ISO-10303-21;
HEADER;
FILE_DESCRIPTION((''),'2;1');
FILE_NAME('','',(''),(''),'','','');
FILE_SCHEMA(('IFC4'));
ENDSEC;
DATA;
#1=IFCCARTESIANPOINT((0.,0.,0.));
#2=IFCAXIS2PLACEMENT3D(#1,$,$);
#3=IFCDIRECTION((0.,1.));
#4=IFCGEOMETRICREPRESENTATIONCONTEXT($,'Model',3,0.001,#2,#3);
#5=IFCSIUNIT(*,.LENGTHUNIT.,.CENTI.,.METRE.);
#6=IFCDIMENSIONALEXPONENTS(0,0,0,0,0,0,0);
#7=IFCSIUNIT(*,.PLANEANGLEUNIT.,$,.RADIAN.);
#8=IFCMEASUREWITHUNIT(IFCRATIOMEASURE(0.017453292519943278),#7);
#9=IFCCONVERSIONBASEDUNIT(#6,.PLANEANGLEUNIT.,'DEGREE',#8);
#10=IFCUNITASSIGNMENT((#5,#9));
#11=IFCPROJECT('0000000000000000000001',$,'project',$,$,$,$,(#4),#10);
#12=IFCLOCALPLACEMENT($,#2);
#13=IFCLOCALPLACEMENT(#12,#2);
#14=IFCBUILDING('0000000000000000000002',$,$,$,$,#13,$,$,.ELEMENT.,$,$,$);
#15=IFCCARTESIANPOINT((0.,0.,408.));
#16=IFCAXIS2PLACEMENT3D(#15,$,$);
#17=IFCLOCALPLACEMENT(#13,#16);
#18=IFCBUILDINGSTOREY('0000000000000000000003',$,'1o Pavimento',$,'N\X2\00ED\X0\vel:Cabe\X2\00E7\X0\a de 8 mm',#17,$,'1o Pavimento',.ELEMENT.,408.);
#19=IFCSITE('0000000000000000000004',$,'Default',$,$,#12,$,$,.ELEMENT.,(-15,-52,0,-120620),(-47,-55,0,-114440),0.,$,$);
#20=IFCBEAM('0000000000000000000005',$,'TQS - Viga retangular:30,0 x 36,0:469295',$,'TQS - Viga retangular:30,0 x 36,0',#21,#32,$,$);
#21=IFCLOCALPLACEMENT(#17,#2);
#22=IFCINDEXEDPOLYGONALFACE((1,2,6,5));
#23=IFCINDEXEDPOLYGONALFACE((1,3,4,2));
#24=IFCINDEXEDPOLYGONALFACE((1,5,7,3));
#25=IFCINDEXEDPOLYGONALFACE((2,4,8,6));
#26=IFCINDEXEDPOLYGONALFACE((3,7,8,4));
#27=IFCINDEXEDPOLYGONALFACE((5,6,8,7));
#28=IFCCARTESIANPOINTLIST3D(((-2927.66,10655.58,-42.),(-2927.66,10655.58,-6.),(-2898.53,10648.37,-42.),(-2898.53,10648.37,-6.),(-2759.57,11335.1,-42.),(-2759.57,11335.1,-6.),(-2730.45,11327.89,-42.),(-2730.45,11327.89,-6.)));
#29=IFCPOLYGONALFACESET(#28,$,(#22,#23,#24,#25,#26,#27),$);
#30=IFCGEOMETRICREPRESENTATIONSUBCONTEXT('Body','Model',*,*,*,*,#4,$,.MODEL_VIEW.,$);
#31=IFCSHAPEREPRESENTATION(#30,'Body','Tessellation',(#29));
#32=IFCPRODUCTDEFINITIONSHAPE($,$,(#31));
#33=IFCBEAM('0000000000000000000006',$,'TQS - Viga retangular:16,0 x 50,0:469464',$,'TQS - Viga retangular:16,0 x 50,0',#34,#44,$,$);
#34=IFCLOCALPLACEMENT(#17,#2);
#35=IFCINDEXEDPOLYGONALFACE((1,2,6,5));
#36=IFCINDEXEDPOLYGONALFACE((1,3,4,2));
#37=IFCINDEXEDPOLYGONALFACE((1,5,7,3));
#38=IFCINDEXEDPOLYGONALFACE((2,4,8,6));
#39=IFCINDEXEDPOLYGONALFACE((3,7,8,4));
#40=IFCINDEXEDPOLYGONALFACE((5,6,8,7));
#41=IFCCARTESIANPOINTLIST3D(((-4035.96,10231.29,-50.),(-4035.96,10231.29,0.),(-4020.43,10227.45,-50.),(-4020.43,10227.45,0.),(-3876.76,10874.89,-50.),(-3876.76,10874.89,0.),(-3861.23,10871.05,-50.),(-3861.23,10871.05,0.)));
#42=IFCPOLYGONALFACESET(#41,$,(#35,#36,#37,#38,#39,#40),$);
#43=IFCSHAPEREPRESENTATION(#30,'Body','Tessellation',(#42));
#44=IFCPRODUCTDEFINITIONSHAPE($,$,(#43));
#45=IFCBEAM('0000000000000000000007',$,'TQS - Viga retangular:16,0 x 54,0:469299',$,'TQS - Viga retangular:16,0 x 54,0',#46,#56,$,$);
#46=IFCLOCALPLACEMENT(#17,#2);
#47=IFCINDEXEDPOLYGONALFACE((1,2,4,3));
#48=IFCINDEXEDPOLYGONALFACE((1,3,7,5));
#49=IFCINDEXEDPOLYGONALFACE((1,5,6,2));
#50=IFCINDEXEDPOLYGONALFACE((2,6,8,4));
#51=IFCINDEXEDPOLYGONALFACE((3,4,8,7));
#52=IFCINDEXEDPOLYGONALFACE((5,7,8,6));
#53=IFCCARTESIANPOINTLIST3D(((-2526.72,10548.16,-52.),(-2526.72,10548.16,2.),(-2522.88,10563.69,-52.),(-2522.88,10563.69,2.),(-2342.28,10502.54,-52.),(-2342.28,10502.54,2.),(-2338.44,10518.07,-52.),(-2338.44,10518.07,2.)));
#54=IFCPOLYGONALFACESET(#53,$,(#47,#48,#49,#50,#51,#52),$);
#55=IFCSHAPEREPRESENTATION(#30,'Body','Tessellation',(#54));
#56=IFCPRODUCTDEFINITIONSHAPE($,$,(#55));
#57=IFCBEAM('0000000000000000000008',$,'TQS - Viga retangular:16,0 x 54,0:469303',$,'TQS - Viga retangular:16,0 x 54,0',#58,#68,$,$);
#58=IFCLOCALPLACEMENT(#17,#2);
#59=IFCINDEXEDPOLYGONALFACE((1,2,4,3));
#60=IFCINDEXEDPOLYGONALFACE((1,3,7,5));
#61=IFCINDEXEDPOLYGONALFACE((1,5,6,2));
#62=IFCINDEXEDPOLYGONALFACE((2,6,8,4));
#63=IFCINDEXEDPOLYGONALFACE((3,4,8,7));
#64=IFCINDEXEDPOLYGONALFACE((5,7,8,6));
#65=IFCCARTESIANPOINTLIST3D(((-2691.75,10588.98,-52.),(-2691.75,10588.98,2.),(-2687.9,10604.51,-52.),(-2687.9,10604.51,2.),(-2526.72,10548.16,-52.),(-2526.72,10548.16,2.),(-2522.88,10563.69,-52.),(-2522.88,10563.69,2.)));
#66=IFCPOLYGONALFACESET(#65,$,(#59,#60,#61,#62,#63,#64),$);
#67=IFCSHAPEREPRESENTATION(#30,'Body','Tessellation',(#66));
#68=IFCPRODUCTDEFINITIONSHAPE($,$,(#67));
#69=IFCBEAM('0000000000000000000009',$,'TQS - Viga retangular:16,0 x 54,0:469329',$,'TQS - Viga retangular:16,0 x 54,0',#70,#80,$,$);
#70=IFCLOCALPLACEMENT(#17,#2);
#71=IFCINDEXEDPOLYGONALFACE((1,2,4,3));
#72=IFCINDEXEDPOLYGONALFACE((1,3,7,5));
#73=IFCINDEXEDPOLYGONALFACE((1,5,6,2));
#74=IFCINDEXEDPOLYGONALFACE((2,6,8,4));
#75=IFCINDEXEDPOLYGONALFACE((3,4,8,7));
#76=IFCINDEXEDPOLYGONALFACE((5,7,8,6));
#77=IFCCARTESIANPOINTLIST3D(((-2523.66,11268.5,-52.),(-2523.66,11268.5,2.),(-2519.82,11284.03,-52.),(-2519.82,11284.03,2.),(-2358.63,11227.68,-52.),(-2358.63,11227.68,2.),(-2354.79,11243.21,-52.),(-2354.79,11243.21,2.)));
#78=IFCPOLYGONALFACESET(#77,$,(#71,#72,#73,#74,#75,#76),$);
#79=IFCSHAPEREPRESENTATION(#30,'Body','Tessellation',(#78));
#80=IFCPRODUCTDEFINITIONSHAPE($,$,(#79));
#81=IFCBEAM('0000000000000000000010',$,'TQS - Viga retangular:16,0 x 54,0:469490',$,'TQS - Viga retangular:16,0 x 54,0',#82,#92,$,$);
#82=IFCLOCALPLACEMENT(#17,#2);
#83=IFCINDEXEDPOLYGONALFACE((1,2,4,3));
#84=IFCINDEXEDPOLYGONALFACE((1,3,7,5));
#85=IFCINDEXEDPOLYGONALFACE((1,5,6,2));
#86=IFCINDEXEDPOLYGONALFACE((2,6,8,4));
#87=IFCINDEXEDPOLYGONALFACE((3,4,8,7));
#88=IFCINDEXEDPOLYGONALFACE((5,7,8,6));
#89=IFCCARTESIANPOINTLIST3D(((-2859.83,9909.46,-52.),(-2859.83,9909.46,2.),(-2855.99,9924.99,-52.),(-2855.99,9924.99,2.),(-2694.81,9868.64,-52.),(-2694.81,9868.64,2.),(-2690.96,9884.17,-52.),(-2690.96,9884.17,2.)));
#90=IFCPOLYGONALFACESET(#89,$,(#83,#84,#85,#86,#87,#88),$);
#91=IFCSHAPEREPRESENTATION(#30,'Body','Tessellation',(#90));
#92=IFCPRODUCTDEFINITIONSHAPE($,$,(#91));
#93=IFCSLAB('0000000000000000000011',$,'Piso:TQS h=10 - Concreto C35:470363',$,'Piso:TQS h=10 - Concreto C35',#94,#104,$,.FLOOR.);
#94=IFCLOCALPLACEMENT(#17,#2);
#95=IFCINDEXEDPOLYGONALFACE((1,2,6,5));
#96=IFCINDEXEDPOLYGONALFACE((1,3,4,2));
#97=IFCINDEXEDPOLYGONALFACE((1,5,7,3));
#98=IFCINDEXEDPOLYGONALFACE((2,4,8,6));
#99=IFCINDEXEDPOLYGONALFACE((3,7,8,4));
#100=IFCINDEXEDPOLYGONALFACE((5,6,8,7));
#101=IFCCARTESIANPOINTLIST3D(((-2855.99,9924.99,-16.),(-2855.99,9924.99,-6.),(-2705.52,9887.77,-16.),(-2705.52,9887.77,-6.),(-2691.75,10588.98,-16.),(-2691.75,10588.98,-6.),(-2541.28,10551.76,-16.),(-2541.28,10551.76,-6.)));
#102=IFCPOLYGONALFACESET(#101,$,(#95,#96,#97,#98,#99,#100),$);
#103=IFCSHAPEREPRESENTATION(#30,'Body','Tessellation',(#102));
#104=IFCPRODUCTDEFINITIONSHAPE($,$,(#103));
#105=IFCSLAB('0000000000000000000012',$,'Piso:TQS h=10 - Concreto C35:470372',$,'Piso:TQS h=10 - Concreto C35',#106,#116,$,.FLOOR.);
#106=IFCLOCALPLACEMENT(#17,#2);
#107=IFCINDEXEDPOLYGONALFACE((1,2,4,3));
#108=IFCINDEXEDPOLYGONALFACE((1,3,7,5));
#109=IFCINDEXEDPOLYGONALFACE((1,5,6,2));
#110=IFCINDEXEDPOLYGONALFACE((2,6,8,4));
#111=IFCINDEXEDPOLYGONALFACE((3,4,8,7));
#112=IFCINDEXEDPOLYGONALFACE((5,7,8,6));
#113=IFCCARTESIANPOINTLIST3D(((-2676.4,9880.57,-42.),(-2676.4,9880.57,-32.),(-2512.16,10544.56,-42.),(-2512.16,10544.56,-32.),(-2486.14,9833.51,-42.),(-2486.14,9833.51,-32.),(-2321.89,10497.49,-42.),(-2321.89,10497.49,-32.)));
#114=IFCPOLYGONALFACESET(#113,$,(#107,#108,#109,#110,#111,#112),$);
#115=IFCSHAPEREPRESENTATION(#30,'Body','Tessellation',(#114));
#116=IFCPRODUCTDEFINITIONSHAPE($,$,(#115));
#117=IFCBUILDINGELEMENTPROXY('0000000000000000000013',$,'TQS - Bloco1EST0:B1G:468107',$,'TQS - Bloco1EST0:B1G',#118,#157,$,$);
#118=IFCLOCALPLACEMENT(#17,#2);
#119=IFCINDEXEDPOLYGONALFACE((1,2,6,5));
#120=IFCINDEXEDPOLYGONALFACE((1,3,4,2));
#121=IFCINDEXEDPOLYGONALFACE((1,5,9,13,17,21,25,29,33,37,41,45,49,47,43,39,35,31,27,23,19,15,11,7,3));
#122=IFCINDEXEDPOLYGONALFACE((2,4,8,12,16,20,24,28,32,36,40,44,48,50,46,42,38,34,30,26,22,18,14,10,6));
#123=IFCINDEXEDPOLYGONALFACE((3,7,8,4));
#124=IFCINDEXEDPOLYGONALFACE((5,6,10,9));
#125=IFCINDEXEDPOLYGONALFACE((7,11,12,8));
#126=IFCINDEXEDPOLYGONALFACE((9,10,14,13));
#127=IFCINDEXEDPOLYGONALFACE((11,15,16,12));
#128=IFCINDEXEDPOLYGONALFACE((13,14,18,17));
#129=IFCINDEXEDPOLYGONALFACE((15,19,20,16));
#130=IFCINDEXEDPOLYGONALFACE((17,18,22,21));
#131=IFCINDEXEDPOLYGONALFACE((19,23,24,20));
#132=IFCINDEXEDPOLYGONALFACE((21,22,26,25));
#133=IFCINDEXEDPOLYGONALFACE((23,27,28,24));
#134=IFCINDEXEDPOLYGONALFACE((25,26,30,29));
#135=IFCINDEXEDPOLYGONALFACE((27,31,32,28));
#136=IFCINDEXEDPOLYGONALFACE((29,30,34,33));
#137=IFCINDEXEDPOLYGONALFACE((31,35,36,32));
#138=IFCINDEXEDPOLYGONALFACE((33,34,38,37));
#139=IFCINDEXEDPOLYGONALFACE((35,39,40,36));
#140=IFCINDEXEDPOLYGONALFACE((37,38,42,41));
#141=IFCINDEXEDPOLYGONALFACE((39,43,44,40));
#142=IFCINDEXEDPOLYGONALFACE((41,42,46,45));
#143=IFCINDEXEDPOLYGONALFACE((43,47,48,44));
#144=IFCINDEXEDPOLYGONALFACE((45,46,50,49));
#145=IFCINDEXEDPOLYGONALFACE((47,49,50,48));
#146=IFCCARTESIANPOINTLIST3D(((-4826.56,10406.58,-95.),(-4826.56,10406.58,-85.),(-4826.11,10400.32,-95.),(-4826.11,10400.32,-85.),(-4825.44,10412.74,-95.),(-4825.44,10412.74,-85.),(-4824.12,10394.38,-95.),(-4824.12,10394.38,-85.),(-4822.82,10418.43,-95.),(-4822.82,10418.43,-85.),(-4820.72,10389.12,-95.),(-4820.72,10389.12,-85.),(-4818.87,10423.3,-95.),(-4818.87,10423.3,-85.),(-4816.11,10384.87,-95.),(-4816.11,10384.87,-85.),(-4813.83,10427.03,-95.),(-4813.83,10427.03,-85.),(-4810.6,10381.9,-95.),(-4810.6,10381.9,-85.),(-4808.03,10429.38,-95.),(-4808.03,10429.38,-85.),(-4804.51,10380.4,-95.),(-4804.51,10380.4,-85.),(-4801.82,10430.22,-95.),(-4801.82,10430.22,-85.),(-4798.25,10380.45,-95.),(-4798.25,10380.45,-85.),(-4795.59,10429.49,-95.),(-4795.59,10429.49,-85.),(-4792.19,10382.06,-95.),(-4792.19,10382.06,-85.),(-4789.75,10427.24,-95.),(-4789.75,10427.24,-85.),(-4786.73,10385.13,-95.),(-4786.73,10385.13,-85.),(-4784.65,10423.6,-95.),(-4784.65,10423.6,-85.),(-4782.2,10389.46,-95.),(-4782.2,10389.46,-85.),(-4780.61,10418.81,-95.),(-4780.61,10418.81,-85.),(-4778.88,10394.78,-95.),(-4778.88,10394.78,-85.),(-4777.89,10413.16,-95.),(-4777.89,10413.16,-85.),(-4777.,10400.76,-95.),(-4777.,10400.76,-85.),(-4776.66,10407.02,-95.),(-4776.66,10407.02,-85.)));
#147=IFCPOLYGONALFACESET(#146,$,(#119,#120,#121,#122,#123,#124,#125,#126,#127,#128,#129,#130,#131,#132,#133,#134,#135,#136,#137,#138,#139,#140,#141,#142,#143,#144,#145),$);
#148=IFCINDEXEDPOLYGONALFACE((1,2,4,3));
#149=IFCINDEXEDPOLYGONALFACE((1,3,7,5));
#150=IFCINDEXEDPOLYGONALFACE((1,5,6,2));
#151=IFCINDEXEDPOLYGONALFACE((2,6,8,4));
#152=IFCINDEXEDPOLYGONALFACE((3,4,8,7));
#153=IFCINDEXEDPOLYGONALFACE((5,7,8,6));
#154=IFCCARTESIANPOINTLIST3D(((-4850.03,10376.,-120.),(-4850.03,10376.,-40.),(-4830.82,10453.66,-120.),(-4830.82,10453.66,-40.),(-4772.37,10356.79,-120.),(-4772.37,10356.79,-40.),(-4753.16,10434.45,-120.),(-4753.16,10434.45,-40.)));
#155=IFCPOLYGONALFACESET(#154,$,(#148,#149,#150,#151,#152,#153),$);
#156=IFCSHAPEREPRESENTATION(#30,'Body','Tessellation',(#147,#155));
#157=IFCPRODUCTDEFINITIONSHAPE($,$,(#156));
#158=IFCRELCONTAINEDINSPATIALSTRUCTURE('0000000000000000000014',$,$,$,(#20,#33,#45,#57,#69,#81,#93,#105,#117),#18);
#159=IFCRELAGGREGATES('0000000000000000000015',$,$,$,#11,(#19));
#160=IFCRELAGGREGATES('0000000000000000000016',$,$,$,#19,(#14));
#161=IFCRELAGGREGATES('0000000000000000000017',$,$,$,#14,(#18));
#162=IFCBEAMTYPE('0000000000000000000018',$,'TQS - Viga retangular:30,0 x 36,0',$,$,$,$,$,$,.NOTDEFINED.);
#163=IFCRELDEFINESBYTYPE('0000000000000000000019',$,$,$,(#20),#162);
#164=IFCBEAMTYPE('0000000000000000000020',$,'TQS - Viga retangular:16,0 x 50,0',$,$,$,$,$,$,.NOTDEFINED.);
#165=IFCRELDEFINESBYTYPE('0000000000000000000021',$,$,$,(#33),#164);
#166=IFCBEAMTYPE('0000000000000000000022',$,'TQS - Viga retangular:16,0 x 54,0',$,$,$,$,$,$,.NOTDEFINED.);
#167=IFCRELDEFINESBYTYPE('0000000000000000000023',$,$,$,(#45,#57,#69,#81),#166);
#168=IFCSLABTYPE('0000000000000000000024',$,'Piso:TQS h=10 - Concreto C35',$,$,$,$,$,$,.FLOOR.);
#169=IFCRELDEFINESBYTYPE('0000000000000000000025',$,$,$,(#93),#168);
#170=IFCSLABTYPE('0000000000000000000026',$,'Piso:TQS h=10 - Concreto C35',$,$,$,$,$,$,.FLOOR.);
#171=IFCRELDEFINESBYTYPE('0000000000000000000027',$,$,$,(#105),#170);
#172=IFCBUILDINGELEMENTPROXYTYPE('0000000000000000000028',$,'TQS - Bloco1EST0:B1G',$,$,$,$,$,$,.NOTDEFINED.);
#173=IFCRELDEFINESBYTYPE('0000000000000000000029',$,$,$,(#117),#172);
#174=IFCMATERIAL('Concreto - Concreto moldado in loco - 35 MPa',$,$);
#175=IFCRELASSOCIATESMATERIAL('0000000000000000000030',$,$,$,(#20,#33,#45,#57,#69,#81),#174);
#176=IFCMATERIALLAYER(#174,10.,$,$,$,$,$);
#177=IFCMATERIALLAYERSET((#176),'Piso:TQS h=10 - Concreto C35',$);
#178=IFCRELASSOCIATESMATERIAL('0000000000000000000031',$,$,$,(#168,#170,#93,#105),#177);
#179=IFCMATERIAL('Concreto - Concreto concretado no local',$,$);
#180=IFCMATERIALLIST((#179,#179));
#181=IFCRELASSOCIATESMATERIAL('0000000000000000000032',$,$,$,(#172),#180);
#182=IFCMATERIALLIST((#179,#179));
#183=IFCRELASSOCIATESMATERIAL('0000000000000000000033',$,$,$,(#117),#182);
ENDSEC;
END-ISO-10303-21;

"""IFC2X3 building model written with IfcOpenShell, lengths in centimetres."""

from ifc_helpers import new_model, entity, si_unit, converted_unit, direction, frame, frame_2d, origin, origin_2d_with_axis, place, context, subcontext, project, spatial, rectangle, circle, extrude, source, transform, mapped, material, material_list, layer, layer_set, layer_usage, type_object, type_shapes, element, save


model = new_model("IFC2X3")

# Units and contexts
model_context = context("Model", 3, precision=0.001, world=origin(), true_north=direction((0.0, 1.0)))
body_context = subcontext(model_context, "Body", "Model", "MODEL_VIEW")
ifc_project = project(units=[si_unit("LENGTHUNIT", "METRE", prefix="CENTI"), converted_unit("PLANEANGLEUNIT", "DEGREE", entity("IfcRatioMeasure", 0.017453292519943278), si_unit("PLANEANGLEUNIT", "RADIAN"), dimensions=[0, 0, 0, 0, 0, 0, 0])], contexts=[model_context])

# Site, building, storey
site_placement = place(None, origin())
site = spatial("IfcSite", under=ifc_project, at=site_placement, Name="Default", CompositionType="ELEMENT", RefLatitude=(-15, -52, 0, -120620), RefLongitude=(-47, -55, 0, -114440), RefElevation=0.0)
building_placement = place(site_placement, origin())
building = spatial("IfcBuilding", under=site, at=building_placement, CompositionType="ELEMENT")
storey_placement = place(building_placement, frame((0.0, 0.0, 408.0)))
storey = spatial("IfcBuildingStorey", under=building, at=storey_placement, Name="1o Pavimento", ObjectType="Nível:Cabeça de 8 mm", LongName="1o Pavimento", CompositionType="ELEMENT", Elevation=408.0)

# Beams
ifc_material_1 = material(Name="Concreto - Concreto moldado in loco - 35 MPa")
beam_type_1 = type_object("IfcBeamType", Name="TQS - Viga retangular:30,0 x 36,0", PredefinedType="NOTDEFINED")
beam_1_placement = place(storey_placement, frame((-2913.1, 10651.97, -6.0), z_axis=(0.0, 0.0, 1.0), x_axis=(0.240122, 0.970743, 0.0)))
element("IfcBeam", 1, at=beam_1_placement, inside=storey, type_object=beam_type_1, material=ifc_material_1, Name="TQS - Viga retangular:30,0 x 36,0:469295", ObjectType="TQS - Viga retangular:30,0 x 36,0", context=body_context, shape_type="SweptSolid", body=[
    extrude(rectangle(XDim=36.0, YDim=30.0, at=frame_2d((0.0, 0.0), x_axis=(1.0, 0.0))), frame((0.0, 0.0, -18.0), z_axis=(1.0, 0.0, 0.0), x_axis=(0.0, 0.0, -1.0)), (0.0, 0.0, 1.0), 700.0),
])
beam_type_2 = type_object("IfcBeamType", Name="TQS - Viga retangular:16,0 x 50,0", PredefinedType="NOTDEFINED")
beam_2_placement = place(storey_placement, frame((-4028.2, 10229.37, 0.0), z_axis=(0.0, 0.0, 1.0), x_axis=(0.240122, 0.970743, 0.0)))
element("IfcBeam", 2, at=beam_2_placement, inside=storey, type_object=beam_type_2, material=ifc_material_1, Name="TQS - Viga retangular:16,0 x 50,0:469464", ObjectType="TQS - Viga retangular:16,0 x 50,0", context=body_context, shape_type="SweptSolid", body=[
    extrude(rectangle(XDim=50.0, YDim=16.0, at=frame_2d((0.0, 0.0), x_axis=(1.0, 0.0))), frame((0.0, 0.0, -25.0), z_axis=(1.0, 0.0, 0.0), x_axis=(0.0, 0.0, -1.0)), (0.0, 0.0, 1.0), 663.0),
])
beam_type_3 = type_object("IfcBeamType", Name="TQS - Viga retangular:16,0 x 54,0", PredefinedType="NOTDEFINED")
beam_3_placement = place(storey_placement, frame((-2340.36, 10510.3, 2.0), z_axis=(0.0, 0.0, 1.0), x_axis=(-0.970743, 0.240122, 0.0)))
element("IfcBeam", 3, at=beam_3_placement, inside=storey, type_object=beam_type_3, material=ifc_material_1, Name="TQS - Viga retangular:16,0 x 54,0:469299", ObjectType="TQS - Viga retangular:16,0 x 54,0", context=body_context, shape_type="SweptSolid", body=[
    extrude(rectangle(XDim=54.0, YDim=16.0, at=frame_2d((0.0, 0.0), x_axis=(1.0, 0.0))), frame((0.0, 0.0, -27.0), z_axis=(1.0, 0.0, 0.0), x_axis=(0.0, 0.0, -1.0)), (0.0, 0.0, 1.0), 190.0),
])
beam_4_placement = place(storey_placement, frame((-2524.8, 10555.93, 2.0), z_axis=(0.0, 0.0, 1.0), x_axis=(-0.970743, 0.240122, 0.0)))
element("IfcBeam", 4, at=beam_4_placement, inside=storey, type_object=beam_type_3, material=ifc_material_1, Name="TQS - Viga retangular:16,0 x 54,0:469303", ObjectType="TQS - Viga retangular:16,0 x 54,0", context=body_context, shape_type="SweptSolid", body=[
    extrude(rectangle(XDim=54.0, YDim=16.0, at=frame_2d((0.0, 0.0), x_axis=(1.0, 0.0))), frame((0.0, 0.0, -27.0), z_axis=(1.0, 0.0, 0.0), x_axis=(0.0, 0.0, -1.0)), (0.0, 0.0, 1.0), 170.0),
])
beam_5_placement = place(storey_placement, frame((-2356.71, 11235.44, 2.0), z_axis=(0.0, 0.0, 1.0), x_axis=(-0.970743, 0.240122, 0.0)))
element("IfcBeam", 5, at=beam_5_placement, inside=storey, type_object=beam_type_3, material=ifc_material_1, Name="TQS - Viga retangular:16,0 x 54,0:469329", ObjectType="TQS - Viga retangular:16,0 x 54,0", context=body_context, shape_type="SweptSolid", body=[
    extrude(rectangle(XDim=54.0, YDim=16.0, at=frame_2d((0.0, 0.0), x_axis=(1.0, 0.0))), frame((0.0, 0.0, -27.0), z_axis=(1.0, 0.0, 0.0), x_axis=(0.0, 0.0, -1.0)), (0.0, 0.0, 1.0), 170.0),
])
beam_6_placement = place(storey_placement, frame((-2692.88, 9876.41, 2.0), z_axis=(0.0, 0.0, 1.0), x_axis=(-0.970743, 0.240122, 0.0)))
element("IfcBeam", 6, at=beam_6_placement, inside=storey, type_object=beam_type_3, material=ifc_material_1, Name="TQS - Viga retangular:16,0 x 54,0:469490", ObjectType="TQS - Viga retangular:16,0 x 54,0", context=body_context, shape_type="SweptSolid", body=[
    extrude(rectangle(XDim=54.0, YDim=16.0, at=frame_2d((0.0, 0.0), x_axis=(1.0, 0.0))), frame((0.0, 0.0, -27.0), z_axis=(1.0, 0.0, 0.0), x_axis=(0.0, 0.0, -1.0)), (0.0, 0.0, 1.0), 170.0),
])

# Slabs
ifc_layer = layer(ifc_material_1, 10.0)
ifc_layer_set = layer_set([ifc_layer], Name="Piso:TQS h=10 - Concreto C35")
ifc_layer_usage_1 = layer_usage(ifc_layer_set, "AXIS3", "POSITIVE", 0.0)
slab_type_1 = type_object("IfcSlabType", Name="Piso:TQS h=10 - Concreto C35", PredefinedType="FLOOR", material=ifc_layer_set)
slab_1_placement = place(storey_placement, origin())
element("IfcSlab", 7, at=slab_1_placement, inside=storey, type_object=slab_type_1, material=ifc_layer_usage_1, Name="Piso:TQS h=10 - Concreto C35:470363", ObjectType="Piso:TQS h=10 - Concreto C35", PredefinedType="FLOOR", context=body_context, shape_type="SweptSolid", body=[
    extrude(rectangle(XDim=155.0, YDim=684.0, at=origin_2d_with_axis()), frame((-2698.64, 10238.38, -6.0), z_axis=(0.0, 0.0, -1.0), x_axis=(0.970743, -0.240122, 0.0)), (0.0, 0.0, 1.0), 10.0),
])
ifc_layer_usage_2 = layer_usage(ifc_layer_set, "AXIS3", "POSITIVE", 0.0)
slab_type_2 = type_object("IfcSlabType", Name="Piso:TQS h=10 - Concreto C35", PredefinedType="FLOOR", material=ifc_layer_set)
slab_2_placement = place(storey_placement, origin())
element("IfcSlab", 8, at=slab_2_placement, inside=storey, type_object=slab_type_2, material=ifc_layer_usage_2, Name="Piso:TQS h=10 - Concreto C35:470372", ObjectType="Piso:TQS h=10 - Concreto C35", PredefinedType="FLOOR", context=body_context, shape_type="SweptSolid", body=[
    extrude(rectangle(XDim=684.0, YDim=196.0, at=frame_2d((0.0, 0.0), x_axis=(1.0, 0.0))), frame((-2499.15, 10189.03, -32.0), z_axis=(0.0, 0.0, -1.0), x_axis=(-0.240122, -0.970743, 0.0)), (0.0, 0.0, 1.0), 10.0),
])

# Building element proxy
ifc_material_2 = material(Name="Concreto - Concreto concretado no local")
ifc_material_list_1 = material_list([ifc_material_2, ifc_material_2])
ifc_material_list_2 = material_list([ifc_material_2, ifc_material_2])
building_element_proxy_type_1 = type_object("IfcBuildingElementProxyType", Name="TQS - Bloco1EST0:B1G", PredefinedType="NOTDEFINED", material=ifc_material_list_2)
shared_shape_1 = source(origin(), body_context, "Body", "SweptSolid", [
    extrude(circle(Radius=25.0, at=frame_2d((0.0, 0.0), x_axis=(1.0, 0.0))), frame((0.0, 0.0, -55.0)), (0.0, 0.0, 1.0), 10.0),
    extrude(rectangle(XDim=80.0, YDim=80.0, at=origin_2d_with_axis()), frame((0.0, 0.0, -80.0), z_axis=(0.0, 0.0, 1.0), x_axis=(-1.0, 0.0, 0.0)), (0.0, 0.0, 1.0), 80.0),
])
type_shapes(building_element_proxy_type_1, [shared_shape_1])
proxy_1_placement = place(storey_placement, frame((-4801.6, 10405.23, -40.0), z_axis=(0.0, 0.0, 1.0), x_axis=(0.240122, 0.970743, 0.0)))
element("IfcBuildingElementProxy", 9, at=proxy_1_placement, inside=storey, type_object=building_element_proxy_type_1, material=ifc_material_list_1, Name="TQS - Bloco1EST0:B1G:468107", ObjectType="TQS - Bloco1EST0:B1G", context=body_context, shape_type="MappedRepresentation", body=[
    mapped(shared_shape_1, transform((0.0, 0.0, 0.0), scale=1.0)),
])

save(model, "model.ifc")
